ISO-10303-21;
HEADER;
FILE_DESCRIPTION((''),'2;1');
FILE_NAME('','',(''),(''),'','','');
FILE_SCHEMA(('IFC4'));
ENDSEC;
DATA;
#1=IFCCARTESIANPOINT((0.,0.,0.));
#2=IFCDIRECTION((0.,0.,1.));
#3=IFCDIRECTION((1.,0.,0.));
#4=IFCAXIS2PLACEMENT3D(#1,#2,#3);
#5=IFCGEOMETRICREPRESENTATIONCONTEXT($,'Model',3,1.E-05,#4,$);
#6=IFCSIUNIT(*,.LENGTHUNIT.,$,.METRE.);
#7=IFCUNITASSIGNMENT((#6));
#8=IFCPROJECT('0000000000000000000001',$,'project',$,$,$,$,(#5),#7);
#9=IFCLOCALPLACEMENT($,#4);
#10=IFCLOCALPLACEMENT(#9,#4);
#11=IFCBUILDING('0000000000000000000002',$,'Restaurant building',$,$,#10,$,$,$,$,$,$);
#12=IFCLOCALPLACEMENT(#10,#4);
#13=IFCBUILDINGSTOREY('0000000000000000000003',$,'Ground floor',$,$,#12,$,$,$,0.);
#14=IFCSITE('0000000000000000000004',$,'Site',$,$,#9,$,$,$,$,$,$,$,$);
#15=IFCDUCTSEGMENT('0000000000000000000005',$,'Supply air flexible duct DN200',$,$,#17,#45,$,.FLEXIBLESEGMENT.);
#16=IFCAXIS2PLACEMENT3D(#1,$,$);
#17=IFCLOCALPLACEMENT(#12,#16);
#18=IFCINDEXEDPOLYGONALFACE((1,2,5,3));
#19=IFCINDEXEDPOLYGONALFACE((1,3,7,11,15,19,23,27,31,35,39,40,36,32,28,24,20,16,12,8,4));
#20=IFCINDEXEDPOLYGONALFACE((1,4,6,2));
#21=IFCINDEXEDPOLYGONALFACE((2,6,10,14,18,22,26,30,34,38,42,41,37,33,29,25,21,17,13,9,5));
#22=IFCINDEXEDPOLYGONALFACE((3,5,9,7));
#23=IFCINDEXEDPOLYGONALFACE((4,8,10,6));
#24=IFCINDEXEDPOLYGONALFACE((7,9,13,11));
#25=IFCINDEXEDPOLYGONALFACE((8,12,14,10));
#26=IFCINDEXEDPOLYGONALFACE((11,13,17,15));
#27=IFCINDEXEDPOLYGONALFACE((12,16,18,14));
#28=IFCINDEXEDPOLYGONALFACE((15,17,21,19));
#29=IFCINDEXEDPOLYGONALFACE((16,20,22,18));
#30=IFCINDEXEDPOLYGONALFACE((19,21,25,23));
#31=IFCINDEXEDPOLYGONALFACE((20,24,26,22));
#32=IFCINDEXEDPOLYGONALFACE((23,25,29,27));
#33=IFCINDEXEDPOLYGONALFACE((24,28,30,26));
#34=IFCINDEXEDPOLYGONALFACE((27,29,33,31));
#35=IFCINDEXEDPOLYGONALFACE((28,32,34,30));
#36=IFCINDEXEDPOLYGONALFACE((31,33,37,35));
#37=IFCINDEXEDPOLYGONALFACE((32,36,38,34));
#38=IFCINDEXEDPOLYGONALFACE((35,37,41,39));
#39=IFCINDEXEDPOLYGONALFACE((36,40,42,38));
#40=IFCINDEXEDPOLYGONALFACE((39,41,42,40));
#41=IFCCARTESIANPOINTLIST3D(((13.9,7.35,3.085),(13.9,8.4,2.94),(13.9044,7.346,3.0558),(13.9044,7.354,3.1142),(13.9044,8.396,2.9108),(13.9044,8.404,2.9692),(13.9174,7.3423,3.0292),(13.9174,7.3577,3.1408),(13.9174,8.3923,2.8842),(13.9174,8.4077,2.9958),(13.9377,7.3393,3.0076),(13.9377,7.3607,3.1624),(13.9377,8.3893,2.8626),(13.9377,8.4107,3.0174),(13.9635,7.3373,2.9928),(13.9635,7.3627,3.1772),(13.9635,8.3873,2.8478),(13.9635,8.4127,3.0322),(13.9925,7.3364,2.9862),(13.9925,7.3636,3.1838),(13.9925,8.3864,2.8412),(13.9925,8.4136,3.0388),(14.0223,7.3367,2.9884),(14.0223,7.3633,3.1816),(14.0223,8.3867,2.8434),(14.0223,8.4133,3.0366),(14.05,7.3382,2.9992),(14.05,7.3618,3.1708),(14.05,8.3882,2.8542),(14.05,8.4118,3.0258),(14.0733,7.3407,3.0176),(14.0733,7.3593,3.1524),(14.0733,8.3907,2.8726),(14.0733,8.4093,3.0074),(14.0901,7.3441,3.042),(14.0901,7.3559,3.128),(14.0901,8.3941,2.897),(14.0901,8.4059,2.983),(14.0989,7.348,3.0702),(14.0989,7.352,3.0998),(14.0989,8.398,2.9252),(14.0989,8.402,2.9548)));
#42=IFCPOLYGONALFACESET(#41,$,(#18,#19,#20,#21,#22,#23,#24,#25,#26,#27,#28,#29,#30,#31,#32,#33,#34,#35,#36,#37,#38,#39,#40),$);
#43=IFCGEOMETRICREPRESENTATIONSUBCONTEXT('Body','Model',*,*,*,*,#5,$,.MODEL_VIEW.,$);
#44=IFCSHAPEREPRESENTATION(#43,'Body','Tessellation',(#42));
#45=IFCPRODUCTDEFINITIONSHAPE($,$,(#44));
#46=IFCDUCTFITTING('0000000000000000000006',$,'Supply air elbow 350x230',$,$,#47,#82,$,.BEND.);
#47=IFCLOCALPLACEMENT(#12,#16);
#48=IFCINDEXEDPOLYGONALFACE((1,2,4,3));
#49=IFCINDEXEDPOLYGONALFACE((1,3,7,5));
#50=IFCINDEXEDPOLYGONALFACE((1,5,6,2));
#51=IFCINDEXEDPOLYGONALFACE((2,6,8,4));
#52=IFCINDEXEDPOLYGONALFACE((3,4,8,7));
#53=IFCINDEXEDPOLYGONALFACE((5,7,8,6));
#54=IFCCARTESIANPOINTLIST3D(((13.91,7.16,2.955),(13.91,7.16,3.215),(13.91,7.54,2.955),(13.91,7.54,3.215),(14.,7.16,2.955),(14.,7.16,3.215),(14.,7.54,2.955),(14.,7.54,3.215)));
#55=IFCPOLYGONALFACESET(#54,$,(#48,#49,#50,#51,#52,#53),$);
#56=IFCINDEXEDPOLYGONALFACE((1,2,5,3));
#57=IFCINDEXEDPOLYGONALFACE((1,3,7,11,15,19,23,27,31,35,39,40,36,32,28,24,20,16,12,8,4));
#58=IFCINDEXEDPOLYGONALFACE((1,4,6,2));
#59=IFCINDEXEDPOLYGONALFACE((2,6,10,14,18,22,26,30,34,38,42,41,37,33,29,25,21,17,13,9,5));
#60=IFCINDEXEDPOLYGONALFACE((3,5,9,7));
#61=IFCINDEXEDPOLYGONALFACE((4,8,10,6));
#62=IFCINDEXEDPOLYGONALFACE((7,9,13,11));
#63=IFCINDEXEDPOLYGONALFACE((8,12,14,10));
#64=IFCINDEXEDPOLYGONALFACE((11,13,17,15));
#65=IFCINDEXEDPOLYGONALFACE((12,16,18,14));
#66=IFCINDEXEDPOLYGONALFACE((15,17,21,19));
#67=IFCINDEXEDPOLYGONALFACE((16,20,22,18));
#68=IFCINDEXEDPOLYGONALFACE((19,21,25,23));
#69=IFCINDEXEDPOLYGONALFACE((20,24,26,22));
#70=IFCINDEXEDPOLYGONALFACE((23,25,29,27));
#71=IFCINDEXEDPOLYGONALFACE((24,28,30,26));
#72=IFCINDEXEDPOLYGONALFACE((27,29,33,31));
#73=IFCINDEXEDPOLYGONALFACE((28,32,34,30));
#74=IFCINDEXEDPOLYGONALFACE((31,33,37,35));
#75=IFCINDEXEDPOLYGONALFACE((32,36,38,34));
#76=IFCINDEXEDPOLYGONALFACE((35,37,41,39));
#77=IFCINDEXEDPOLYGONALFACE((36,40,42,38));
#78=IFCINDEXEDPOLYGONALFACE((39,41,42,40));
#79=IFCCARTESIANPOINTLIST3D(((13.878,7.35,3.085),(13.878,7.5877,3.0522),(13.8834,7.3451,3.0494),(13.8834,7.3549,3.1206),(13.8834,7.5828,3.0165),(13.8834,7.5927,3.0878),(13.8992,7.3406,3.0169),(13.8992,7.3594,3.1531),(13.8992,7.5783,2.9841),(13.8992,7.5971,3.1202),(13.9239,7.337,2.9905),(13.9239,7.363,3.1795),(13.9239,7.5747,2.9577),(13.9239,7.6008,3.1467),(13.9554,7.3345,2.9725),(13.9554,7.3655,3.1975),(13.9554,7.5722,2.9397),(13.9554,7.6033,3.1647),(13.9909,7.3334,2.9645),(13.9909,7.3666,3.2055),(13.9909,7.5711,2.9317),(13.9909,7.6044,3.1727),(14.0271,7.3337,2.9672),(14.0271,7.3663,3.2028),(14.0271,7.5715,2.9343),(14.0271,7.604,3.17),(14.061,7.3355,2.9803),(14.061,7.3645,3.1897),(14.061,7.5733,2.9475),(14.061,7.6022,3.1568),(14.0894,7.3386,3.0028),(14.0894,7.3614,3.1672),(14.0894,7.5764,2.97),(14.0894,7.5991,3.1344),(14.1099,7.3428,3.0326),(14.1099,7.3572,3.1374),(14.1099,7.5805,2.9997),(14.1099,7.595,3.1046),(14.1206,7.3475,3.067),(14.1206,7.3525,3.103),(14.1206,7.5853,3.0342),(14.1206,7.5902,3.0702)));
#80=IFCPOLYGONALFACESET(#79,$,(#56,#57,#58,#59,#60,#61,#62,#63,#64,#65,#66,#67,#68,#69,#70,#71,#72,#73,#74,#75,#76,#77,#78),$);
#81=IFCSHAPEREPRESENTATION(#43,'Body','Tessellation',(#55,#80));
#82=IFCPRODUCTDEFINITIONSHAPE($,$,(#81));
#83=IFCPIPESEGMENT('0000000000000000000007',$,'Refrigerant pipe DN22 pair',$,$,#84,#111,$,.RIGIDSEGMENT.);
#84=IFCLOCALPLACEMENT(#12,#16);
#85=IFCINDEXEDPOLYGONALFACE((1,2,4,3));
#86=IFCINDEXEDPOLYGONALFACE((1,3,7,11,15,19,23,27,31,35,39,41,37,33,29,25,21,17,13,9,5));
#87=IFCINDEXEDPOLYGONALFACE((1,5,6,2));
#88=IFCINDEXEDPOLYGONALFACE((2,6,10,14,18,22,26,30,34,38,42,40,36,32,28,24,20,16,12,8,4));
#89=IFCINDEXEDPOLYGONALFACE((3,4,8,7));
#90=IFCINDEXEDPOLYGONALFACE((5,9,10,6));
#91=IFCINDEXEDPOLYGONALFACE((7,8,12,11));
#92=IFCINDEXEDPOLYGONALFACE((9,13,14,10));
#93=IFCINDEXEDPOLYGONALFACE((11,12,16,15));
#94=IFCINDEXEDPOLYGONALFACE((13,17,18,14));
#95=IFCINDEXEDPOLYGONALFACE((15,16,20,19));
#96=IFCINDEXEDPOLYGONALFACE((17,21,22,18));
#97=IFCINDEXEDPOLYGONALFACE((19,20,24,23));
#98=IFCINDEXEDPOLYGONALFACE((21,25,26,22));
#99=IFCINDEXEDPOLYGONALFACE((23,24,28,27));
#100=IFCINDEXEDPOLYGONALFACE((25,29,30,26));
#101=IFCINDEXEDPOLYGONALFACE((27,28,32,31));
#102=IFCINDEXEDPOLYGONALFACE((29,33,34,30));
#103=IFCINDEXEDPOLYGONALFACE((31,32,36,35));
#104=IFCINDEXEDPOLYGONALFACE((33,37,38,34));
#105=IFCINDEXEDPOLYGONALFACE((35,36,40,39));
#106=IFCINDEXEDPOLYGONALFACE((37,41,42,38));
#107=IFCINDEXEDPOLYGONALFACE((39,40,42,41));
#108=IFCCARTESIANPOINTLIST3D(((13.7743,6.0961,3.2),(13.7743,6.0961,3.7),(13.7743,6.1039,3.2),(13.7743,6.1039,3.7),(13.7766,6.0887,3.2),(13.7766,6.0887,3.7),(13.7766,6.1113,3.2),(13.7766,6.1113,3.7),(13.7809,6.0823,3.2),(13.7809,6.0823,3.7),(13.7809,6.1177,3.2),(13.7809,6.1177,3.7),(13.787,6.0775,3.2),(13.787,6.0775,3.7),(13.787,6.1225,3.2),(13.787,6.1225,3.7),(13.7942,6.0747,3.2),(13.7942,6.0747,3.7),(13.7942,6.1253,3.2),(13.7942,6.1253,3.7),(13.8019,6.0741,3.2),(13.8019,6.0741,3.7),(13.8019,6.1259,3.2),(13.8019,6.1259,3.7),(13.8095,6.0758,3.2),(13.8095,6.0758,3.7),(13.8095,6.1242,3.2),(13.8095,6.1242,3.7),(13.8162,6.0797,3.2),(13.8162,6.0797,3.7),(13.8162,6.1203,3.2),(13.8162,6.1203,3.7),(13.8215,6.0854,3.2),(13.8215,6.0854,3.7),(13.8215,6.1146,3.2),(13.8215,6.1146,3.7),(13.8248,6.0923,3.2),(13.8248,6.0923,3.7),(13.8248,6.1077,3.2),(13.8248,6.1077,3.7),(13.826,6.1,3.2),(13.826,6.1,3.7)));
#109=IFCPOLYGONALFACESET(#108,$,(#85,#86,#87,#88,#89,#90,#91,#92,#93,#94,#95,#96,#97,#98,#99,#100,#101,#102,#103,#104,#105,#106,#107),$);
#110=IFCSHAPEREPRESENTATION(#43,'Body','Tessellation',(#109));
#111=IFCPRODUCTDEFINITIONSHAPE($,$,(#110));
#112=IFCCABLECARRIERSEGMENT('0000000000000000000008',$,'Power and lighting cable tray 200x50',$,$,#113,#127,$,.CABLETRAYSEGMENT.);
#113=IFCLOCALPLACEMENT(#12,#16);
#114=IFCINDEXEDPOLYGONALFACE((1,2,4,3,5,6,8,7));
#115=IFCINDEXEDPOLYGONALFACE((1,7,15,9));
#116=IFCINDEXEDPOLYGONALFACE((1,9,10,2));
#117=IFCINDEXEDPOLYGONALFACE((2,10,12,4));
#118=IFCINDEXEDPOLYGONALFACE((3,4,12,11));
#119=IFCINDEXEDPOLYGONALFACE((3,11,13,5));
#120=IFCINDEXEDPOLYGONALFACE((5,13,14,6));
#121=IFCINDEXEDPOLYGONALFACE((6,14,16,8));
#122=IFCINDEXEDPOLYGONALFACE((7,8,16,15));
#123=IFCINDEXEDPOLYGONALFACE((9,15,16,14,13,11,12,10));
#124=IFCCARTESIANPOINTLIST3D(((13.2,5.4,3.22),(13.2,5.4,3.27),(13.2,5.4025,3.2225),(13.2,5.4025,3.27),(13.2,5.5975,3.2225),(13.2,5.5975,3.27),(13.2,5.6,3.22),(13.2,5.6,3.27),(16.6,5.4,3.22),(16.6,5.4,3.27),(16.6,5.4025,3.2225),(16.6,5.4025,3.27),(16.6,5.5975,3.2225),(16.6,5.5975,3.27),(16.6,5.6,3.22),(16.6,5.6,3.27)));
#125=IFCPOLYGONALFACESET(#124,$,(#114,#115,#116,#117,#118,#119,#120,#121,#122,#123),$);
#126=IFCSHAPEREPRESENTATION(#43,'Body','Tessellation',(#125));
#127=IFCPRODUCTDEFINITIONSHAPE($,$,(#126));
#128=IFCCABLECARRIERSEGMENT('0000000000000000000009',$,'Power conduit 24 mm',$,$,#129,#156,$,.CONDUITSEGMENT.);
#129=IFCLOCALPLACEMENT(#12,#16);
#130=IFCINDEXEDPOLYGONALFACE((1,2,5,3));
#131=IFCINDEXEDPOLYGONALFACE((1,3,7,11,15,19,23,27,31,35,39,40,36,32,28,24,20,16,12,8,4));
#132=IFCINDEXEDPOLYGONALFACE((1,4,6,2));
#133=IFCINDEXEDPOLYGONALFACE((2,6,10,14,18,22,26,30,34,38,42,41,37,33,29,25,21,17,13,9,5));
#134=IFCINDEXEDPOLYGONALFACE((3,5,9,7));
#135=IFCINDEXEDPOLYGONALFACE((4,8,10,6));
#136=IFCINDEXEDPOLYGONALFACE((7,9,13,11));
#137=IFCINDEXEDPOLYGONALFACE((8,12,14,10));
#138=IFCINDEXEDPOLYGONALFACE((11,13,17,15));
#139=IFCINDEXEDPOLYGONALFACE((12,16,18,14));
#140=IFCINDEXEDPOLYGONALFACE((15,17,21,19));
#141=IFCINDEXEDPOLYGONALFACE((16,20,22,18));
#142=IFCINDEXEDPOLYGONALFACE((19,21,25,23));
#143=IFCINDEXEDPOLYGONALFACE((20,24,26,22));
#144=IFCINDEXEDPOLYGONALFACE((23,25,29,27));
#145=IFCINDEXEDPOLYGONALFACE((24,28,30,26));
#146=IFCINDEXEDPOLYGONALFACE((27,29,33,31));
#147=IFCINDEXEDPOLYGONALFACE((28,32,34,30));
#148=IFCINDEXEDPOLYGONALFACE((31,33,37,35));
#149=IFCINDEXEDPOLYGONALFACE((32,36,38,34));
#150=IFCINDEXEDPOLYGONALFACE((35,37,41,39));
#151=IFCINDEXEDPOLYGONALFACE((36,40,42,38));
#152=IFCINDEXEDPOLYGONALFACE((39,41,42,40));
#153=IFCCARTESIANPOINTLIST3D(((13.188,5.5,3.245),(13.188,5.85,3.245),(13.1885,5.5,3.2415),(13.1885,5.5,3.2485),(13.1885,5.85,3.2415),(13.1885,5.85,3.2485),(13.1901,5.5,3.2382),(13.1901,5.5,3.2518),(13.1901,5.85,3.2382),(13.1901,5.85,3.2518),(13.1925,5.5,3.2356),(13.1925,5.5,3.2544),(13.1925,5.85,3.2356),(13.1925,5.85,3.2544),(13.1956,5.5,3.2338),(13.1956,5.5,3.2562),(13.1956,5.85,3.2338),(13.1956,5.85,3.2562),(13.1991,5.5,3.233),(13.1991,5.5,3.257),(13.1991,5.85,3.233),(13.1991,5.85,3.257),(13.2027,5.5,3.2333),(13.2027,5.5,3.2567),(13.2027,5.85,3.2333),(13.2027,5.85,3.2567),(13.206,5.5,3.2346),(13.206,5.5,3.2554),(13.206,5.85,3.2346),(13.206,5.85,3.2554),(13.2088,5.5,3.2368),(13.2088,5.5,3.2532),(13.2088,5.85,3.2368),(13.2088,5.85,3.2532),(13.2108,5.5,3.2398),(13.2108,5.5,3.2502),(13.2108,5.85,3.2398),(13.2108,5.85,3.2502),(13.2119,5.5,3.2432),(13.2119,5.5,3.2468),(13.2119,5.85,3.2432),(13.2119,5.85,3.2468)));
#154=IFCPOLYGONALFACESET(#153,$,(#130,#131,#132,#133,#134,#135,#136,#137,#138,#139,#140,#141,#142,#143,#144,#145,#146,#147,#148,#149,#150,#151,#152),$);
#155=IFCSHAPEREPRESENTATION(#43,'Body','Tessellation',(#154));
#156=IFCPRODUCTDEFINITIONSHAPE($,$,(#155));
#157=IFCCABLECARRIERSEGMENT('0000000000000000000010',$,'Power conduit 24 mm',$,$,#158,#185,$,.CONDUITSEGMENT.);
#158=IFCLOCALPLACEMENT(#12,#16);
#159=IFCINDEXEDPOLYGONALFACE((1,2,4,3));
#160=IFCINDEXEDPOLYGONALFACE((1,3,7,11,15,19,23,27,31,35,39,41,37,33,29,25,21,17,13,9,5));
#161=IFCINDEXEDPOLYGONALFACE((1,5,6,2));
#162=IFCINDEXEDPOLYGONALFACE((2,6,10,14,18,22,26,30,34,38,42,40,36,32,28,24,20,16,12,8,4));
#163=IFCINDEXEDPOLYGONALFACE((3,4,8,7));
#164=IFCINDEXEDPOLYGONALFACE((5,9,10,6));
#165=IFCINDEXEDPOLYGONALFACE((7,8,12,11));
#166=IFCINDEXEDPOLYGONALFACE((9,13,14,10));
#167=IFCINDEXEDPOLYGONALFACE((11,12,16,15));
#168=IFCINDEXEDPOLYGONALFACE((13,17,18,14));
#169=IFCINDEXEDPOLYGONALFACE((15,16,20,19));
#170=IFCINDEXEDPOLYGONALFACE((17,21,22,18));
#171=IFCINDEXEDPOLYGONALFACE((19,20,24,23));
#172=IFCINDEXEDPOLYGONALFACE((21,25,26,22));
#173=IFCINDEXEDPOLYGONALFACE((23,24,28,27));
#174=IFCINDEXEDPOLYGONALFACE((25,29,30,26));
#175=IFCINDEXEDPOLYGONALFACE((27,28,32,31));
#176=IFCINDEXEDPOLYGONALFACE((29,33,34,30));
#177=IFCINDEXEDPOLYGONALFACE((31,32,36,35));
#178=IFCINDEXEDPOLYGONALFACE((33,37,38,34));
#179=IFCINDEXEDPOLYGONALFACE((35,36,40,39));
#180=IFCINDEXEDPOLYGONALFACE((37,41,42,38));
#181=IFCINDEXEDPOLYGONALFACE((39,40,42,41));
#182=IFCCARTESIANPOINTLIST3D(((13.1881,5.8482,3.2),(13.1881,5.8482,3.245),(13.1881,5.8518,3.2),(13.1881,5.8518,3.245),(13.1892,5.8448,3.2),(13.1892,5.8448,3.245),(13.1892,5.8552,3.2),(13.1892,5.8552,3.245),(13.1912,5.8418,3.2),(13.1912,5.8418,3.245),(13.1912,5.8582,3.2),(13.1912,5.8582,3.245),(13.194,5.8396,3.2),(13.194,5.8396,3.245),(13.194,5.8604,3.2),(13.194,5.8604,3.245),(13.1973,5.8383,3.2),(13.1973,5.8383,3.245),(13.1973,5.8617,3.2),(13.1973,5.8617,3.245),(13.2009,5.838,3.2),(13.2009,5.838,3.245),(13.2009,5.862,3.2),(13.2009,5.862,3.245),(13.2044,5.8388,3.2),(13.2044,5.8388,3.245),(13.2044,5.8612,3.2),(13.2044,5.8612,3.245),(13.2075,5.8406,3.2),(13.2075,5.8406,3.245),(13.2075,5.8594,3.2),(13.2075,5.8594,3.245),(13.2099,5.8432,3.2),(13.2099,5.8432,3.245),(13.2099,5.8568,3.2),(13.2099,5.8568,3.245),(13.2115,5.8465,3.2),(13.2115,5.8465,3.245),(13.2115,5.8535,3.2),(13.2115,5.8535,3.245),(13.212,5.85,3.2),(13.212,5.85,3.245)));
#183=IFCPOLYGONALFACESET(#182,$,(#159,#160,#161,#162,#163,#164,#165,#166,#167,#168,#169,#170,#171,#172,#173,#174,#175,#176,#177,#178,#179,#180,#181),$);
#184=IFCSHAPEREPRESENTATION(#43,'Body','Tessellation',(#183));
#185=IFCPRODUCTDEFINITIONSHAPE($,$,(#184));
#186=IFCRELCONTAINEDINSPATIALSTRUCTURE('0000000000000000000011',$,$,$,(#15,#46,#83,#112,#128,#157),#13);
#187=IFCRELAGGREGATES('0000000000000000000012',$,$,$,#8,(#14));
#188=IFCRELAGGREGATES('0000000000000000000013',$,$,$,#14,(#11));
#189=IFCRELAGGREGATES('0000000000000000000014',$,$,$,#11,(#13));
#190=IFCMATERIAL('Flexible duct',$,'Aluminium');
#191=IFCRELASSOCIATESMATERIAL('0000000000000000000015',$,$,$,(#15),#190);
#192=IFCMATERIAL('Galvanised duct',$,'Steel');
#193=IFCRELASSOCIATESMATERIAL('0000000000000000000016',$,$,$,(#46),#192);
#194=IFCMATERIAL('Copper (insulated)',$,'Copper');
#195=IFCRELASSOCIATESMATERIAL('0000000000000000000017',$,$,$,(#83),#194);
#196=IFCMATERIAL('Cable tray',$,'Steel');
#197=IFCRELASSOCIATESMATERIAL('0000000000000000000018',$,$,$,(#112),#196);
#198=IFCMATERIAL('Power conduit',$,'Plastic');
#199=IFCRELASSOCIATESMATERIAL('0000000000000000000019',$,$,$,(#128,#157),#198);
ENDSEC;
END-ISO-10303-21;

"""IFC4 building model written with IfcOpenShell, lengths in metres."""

from ifc_helpers import new_model, si_unit, frame, origin_with_axes, origin_2d, place, context, subcontext, project, spatial, polyline, rectangle, circle, outline, extrude, material, element, save


model = new_model("IFC4")

# Units and contexts
model_context = context("Model", 3, precision=1e-05, world=origin_with_axes())
body_context = subcontext(model_context, "Body", "Model", "MODEL_VIEW")
ifc_project = project(units=[si_unit("LENGTHUNIT", "METRE")], contexts=[model_context])

# Site, building, storey
site_placement = place(None, origin_with_axes())
site = spatial("IfcSite", under=ifc_project, at=site_placement, Name="Site")
building_placement = place(site_placement, origin_with_axes())
building = spatial("IfcBuilding", under=site, at=building_placement, Name="Restaurant building")
storey_placement = place(building_placement, origin_with_axes())
storey = spatial("IfcBuildingStorey", under=building, at=storey_placement, Name="Ground floor", Elevation=0.0)

# Duct segment
ifc_material_1 = material(Name="Galvanised duct", Category="Steel")
ifc_material_2 = material(Name="Flexible duct", Category="Aluminium")
duct_segment_1_placement = place(storey_placement, frame((14.0, 7.35, 3.085)))
element("IfcDuctSegment", 1, at=duct_segment_1_placement, inside=storey, material=ifc_material_2, Name="Supply air flexible duct DN200", PredefinedType="FLEXIBLESEGMENT", context=body_context, shape_type="SweptSolid", body=[
    extrude(circle(Radius=0.1, at=origin_2d()), frame((0.0, 0.0, 0.0), z_axis=(0.0, 0.990599, -0.136797), x_axis=(-1.0, 0.0, 0.0)), (0.0, 0.0, 1.0), 1.06),
])

# Duct fitting
duct_fitting_placement = place(storey_placement, frame((14.0, 7.35, 3.085)))
element("IfcDuctFitting", 2, at=duct_fitting_placement, inside=storey, material=ifc_material_1, Name="Supply air elbow 350x230", PredefinedType="BEND", context=body_context, shape_type="SweptSolid", body=[
    extrude(rectangle(XDim=0.38, YDim=0.26, at=origin_2d()), frame((0.0, 0.0, 0.0), z_axis=(-1.0, 0.0, 0.0), x_axis=(0.0, -1.0, 0.0)), (0.0, 0.0, 1.0), 0.09),
    extrude(circle(Radius=0.122, at=origin_2d()), frame((0.0, 0.0, 0.0), z_axis=(0.0, 0.990599, -0.136797), x_axis=(-1.0, 0.0, 0.0)), (0.0, 0.0, 1.0), 0.24),
])

# Pipe segment
ifc_material_3 = material(Name="Copper (insulated)", Category="Copper")
pipe_segment_1_placement = place(storey_placement, frame((13.8, 6.1, 3.7)))
element("IfcPipeSegment", 3, at=pipe_segment_1_placement, inside=storey, material=ifc_material_3, Name="Refrigerant pipe DN22 pair", PredefinedType="RIGIDSEGMENT", context=body_context, shape_type="SweptSolid", body=[
    extrude(circle(Radius=0.026, at=origin_2d()), frame((0.0, 0.0, 0.0), z_axis=(0.0, 0.0, -1.0), x_axis=(1.0, 0.0, 0.0)), (0.0, 0.0, 1.0), 0.5),
])

# Cable carrier segments
ifc_material_4 = material(Name="Cable tray", Category="Steel")
cable_carrier_segment_1_placement = place(storey_placement, frame((13.2, 5.5, 3.245)))
element("IfcCableCarrierSegment", 4, at=cable_carrier_segment_1_placement, inside=storey, material=ifc_material_4, Name="Power and lighting cable tray 200x50", PredefinedType="CABLETRAYSEGMENT", context=body_context, shape_type="SweptSolid", body=[
    extrude(outline(polyline([(-0.1, -0.025), (0.1, -0.025), (0.1, 0.025), (0.0975, 0.025), (0.0975, -0.0225), (-0.0975, -0.0225), (-0.0975, 0.025), (-0.1, 0.025), (-0.1, -0.025)])), frame((0.0, 0.0, 0.0), z_axis=(1.0, 0.0, 0.0), x_axis=(0.0, 1.0, 0.0)), (0.0, 0.0, 1.0), 3.4),
])
ifc_material_5 = material(Name="Power conduit", Category="Plastic")
cable_carrier_segment_2_placement = place(storey_placement, frame((13.2, 5.5, 3.245)))
element("IfcCableCarrierSegment", 5, at=cable_carrier_segment_2_placement, inside=storey, material=ifc_material_5, Name="Power conduit 24 mm", PredefinedType="CONDUITSEGMENT", context=body_context, shape_type="SweptSolid", body=[
    extrude(circle(Radius=0.012, at=origin_2d()), frame((0.0, 0.0, 0.0), z_axis=(0.0, 1.0, 0.0), x_axis=(-1.0, 0.0, 0.0)), (0.0, 0.0, 1.0), 0.35),
])
cable_carrier_segment_3_placement = place(storey_placement, frame((13.2, 5.85, 3.245)))
element("IfcCableCarrierSegment", 6, at=cable_carrier_segment_3_placement, inside=storey, material=ifc_material_5, Name="Power conduit 24 mm", PredefinedType="CONDUITSEGMENT", context=body_context, shape_type="SweptSolid", body=[
    extrude(circle(Radius=0.012, at=origin_2d()), frame((0.0, 0.0, 0.0), z_axis=(0.0, 0.0, -1.0), x_axis=(1.0, 0.0, 0.0)), (0.0, 0.0, 1.0), 0.045),
])

save(model, "model.ifc")
